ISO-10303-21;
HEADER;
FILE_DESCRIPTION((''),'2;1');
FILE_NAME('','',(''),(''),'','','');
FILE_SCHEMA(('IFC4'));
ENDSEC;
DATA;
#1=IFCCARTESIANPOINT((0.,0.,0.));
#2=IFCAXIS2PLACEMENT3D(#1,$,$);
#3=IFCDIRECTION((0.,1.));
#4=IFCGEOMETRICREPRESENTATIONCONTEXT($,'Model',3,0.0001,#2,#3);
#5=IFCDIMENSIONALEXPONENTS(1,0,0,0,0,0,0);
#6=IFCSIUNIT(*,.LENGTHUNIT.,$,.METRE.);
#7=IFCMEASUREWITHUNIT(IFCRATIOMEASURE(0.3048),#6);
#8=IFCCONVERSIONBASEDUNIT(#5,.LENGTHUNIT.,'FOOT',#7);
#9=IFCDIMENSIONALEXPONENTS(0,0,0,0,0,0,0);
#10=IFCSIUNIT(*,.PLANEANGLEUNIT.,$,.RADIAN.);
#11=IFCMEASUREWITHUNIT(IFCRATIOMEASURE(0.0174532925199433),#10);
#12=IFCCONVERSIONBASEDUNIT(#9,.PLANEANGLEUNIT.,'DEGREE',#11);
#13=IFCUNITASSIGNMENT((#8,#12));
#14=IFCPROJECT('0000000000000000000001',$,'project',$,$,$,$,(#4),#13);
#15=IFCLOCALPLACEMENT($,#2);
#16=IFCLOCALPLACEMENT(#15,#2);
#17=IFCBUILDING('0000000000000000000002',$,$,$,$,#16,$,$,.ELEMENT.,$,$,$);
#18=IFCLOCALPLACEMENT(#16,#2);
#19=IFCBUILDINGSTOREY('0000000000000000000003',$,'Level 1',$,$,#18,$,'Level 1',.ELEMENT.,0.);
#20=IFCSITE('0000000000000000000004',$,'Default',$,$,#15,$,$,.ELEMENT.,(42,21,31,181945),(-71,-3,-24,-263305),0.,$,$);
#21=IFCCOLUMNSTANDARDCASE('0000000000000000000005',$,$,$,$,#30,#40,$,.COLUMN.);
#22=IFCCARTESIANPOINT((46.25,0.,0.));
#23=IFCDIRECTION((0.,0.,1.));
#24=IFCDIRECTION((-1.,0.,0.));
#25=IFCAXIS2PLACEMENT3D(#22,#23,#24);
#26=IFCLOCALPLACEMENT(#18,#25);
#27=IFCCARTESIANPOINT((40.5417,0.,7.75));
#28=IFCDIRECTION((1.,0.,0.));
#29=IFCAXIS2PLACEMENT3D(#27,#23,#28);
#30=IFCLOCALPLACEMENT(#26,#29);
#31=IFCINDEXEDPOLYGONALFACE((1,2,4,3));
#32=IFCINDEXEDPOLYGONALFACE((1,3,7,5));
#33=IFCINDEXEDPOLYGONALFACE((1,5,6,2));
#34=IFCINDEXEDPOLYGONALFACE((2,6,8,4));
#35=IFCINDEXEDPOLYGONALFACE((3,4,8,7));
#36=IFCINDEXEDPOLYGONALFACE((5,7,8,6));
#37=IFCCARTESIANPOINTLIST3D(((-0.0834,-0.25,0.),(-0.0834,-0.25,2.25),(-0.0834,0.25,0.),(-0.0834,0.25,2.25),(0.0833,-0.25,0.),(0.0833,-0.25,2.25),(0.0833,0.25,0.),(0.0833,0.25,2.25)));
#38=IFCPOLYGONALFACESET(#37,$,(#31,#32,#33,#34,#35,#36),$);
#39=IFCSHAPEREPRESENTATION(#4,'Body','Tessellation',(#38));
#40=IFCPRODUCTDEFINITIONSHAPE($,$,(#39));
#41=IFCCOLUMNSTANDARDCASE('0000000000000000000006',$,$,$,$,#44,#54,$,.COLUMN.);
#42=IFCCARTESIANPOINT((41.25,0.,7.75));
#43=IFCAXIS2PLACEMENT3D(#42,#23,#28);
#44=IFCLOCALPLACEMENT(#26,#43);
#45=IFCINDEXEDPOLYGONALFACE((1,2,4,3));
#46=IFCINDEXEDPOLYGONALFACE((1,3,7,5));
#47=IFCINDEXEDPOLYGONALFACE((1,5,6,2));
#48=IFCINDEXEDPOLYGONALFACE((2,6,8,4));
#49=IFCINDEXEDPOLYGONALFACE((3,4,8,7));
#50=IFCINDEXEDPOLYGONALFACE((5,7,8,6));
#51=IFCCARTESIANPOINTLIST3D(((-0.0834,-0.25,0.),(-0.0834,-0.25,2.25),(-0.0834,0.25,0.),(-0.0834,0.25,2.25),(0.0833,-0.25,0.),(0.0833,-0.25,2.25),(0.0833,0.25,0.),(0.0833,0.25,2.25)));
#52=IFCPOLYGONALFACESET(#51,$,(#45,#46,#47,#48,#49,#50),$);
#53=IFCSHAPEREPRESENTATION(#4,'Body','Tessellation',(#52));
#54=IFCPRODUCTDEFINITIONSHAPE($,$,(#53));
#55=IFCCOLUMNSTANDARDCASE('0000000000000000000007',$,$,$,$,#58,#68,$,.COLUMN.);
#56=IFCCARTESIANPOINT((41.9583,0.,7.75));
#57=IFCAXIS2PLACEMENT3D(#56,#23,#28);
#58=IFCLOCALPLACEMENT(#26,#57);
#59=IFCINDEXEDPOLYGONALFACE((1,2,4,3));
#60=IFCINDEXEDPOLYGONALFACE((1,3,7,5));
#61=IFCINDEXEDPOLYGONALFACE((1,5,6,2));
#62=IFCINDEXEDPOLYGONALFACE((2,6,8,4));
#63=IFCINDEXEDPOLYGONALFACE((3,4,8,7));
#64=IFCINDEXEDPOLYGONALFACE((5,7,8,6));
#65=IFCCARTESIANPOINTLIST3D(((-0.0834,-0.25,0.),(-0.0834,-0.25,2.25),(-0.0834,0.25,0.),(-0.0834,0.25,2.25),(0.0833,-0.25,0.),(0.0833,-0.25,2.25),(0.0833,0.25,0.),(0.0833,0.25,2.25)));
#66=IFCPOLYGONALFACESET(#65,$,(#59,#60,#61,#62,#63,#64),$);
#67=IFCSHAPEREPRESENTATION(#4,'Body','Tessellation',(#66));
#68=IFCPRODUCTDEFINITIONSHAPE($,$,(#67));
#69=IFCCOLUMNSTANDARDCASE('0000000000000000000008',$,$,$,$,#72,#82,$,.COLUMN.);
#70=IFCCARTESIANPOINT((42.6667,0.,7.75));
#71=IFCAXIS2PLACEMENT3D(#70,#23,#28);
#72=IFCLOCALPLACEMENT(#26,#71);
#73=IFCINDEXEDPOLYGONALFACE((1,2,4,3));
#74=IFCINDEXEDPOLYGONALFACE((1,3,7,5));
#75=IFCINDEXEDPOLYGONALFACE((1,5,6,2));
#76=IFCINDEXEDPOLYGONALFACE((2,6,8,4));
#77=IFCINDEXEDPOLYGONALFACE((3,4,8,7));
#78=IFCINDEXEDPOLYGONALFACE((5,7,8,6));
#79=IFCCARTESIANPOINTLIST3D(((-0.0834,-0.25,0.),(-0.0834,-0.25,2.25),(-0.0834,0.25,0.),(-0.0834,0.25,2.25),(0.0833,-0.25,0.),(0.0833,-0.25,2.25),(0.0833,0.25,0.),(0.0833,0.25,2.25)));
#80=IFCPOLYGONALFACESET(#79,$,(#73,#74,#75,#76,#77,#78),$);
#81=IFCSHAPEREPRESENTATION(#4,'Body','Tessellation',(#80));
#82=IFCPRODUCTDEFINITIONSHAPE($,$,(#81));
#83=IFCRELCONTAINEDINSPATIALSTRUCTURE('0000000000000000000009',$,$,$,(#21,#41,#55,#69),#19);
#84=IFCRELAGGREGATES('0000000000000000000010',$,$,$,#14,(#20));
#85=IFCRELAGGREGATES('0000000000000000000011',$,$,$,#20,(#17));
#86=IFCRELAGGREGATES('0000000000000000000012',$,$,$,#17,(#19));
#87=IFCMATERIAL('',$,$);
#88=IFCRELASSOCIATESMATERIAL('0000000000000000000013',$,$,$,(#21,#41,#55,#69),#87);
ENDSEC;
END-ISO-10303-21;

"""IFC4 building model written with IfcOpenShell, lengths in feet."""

from ifc_helpers import new_model, entity, si_unit, converted_unit, direction, frame, origin, place, context, project, spatial, rectangle, extrude, material, element, save


model = new_model("IFC4")

# Units and contexts
model_context = context("Model", 3, precision=0.0001, world=origin(), true_north=direction((0.0, 1.0)))
ifc_project = project(units=[converted_unit("LENGTHUNIT", "FOOT", entity("IfcRatioMeasure", 0.3048), si_unit("LENGTHUNIT", "METRE"), dimensions=[1, 0, 0, 0, 0, 0, 0]), converted_unit("PLANEANGLEUNIT", "DEGREE", entity("IfcRatioMeasure", 0.0174532925199433), si_unit("PLANEANGLEUNIT", "RADIAN"), dimensions=[0, 0, 0, 0, 0, 0, 0])], contexts=[model_context])

# Site, building, storey
site_placement = place(None, origin())
site = spatial("IfcSite", under=ifc_project, at=site_placement, Name="Default", CompositionType="ELEMENT", RefLatitude=(42, 21, 31, 181945), RefLongitude=(-71, -3, -24, -263305), RefElevation=0.0)
building_placement = place(site_placement, origin())
building = spatial("IfcBuilding", under=site, at=building_placement, CompositionType="ELEMENT")
storey_placement = place(building_placement, origin())
storey = spatial("IfcBuildingStorey", under=building, at=storey_placement, Name="Level 1", LongName="Level 1", CompositionType="ELEMENT", Elevation=0.0)

# Columns
ifc_material_1 = material(Name="")
placement_1 = place(storey_placement, frame((46.25, 0.0, 0.0), z_axis=(0.0, 0.0, 1.0), x_axis=(-1.0, 0.0, 0.0)))
for number, where, z_axis, x_axis in (
    (1, (40.5417, 0.0, 7.75), (0.0, 0.0, 1.0), (1.0, 0.0, 0.0)),
    (2, (41.25, 0.0, 7.75), (0.0, 0.0, 1.0), (1.0, 0.0, 0.0)),
    (3, (41.9583, 0.0, 7.75), (0.0, 0.0, 1.0), (1.0, 0.0, 0.0)),
    (4, (42.6667, 0.0, 7.75), (0.0, 0.0, 1.0), (1.0, 0.0, 0.0)),
):
    element("IfcColumnStandardCase", number, at=place(placement_1, frame(where, z_axis=z_axis, x_axis=x_axis)), inside=storey, material=ifc_material_1, PredefinedType="COLUMN", context=model_context, shape_type="SweptSolid", body=[
        extrude(rectangle(XDim=0.1667, YDim=0.5), origin(), (0.0, 0.0, 1.0), 2.25),
    ])

save(model, "model.ifc")
